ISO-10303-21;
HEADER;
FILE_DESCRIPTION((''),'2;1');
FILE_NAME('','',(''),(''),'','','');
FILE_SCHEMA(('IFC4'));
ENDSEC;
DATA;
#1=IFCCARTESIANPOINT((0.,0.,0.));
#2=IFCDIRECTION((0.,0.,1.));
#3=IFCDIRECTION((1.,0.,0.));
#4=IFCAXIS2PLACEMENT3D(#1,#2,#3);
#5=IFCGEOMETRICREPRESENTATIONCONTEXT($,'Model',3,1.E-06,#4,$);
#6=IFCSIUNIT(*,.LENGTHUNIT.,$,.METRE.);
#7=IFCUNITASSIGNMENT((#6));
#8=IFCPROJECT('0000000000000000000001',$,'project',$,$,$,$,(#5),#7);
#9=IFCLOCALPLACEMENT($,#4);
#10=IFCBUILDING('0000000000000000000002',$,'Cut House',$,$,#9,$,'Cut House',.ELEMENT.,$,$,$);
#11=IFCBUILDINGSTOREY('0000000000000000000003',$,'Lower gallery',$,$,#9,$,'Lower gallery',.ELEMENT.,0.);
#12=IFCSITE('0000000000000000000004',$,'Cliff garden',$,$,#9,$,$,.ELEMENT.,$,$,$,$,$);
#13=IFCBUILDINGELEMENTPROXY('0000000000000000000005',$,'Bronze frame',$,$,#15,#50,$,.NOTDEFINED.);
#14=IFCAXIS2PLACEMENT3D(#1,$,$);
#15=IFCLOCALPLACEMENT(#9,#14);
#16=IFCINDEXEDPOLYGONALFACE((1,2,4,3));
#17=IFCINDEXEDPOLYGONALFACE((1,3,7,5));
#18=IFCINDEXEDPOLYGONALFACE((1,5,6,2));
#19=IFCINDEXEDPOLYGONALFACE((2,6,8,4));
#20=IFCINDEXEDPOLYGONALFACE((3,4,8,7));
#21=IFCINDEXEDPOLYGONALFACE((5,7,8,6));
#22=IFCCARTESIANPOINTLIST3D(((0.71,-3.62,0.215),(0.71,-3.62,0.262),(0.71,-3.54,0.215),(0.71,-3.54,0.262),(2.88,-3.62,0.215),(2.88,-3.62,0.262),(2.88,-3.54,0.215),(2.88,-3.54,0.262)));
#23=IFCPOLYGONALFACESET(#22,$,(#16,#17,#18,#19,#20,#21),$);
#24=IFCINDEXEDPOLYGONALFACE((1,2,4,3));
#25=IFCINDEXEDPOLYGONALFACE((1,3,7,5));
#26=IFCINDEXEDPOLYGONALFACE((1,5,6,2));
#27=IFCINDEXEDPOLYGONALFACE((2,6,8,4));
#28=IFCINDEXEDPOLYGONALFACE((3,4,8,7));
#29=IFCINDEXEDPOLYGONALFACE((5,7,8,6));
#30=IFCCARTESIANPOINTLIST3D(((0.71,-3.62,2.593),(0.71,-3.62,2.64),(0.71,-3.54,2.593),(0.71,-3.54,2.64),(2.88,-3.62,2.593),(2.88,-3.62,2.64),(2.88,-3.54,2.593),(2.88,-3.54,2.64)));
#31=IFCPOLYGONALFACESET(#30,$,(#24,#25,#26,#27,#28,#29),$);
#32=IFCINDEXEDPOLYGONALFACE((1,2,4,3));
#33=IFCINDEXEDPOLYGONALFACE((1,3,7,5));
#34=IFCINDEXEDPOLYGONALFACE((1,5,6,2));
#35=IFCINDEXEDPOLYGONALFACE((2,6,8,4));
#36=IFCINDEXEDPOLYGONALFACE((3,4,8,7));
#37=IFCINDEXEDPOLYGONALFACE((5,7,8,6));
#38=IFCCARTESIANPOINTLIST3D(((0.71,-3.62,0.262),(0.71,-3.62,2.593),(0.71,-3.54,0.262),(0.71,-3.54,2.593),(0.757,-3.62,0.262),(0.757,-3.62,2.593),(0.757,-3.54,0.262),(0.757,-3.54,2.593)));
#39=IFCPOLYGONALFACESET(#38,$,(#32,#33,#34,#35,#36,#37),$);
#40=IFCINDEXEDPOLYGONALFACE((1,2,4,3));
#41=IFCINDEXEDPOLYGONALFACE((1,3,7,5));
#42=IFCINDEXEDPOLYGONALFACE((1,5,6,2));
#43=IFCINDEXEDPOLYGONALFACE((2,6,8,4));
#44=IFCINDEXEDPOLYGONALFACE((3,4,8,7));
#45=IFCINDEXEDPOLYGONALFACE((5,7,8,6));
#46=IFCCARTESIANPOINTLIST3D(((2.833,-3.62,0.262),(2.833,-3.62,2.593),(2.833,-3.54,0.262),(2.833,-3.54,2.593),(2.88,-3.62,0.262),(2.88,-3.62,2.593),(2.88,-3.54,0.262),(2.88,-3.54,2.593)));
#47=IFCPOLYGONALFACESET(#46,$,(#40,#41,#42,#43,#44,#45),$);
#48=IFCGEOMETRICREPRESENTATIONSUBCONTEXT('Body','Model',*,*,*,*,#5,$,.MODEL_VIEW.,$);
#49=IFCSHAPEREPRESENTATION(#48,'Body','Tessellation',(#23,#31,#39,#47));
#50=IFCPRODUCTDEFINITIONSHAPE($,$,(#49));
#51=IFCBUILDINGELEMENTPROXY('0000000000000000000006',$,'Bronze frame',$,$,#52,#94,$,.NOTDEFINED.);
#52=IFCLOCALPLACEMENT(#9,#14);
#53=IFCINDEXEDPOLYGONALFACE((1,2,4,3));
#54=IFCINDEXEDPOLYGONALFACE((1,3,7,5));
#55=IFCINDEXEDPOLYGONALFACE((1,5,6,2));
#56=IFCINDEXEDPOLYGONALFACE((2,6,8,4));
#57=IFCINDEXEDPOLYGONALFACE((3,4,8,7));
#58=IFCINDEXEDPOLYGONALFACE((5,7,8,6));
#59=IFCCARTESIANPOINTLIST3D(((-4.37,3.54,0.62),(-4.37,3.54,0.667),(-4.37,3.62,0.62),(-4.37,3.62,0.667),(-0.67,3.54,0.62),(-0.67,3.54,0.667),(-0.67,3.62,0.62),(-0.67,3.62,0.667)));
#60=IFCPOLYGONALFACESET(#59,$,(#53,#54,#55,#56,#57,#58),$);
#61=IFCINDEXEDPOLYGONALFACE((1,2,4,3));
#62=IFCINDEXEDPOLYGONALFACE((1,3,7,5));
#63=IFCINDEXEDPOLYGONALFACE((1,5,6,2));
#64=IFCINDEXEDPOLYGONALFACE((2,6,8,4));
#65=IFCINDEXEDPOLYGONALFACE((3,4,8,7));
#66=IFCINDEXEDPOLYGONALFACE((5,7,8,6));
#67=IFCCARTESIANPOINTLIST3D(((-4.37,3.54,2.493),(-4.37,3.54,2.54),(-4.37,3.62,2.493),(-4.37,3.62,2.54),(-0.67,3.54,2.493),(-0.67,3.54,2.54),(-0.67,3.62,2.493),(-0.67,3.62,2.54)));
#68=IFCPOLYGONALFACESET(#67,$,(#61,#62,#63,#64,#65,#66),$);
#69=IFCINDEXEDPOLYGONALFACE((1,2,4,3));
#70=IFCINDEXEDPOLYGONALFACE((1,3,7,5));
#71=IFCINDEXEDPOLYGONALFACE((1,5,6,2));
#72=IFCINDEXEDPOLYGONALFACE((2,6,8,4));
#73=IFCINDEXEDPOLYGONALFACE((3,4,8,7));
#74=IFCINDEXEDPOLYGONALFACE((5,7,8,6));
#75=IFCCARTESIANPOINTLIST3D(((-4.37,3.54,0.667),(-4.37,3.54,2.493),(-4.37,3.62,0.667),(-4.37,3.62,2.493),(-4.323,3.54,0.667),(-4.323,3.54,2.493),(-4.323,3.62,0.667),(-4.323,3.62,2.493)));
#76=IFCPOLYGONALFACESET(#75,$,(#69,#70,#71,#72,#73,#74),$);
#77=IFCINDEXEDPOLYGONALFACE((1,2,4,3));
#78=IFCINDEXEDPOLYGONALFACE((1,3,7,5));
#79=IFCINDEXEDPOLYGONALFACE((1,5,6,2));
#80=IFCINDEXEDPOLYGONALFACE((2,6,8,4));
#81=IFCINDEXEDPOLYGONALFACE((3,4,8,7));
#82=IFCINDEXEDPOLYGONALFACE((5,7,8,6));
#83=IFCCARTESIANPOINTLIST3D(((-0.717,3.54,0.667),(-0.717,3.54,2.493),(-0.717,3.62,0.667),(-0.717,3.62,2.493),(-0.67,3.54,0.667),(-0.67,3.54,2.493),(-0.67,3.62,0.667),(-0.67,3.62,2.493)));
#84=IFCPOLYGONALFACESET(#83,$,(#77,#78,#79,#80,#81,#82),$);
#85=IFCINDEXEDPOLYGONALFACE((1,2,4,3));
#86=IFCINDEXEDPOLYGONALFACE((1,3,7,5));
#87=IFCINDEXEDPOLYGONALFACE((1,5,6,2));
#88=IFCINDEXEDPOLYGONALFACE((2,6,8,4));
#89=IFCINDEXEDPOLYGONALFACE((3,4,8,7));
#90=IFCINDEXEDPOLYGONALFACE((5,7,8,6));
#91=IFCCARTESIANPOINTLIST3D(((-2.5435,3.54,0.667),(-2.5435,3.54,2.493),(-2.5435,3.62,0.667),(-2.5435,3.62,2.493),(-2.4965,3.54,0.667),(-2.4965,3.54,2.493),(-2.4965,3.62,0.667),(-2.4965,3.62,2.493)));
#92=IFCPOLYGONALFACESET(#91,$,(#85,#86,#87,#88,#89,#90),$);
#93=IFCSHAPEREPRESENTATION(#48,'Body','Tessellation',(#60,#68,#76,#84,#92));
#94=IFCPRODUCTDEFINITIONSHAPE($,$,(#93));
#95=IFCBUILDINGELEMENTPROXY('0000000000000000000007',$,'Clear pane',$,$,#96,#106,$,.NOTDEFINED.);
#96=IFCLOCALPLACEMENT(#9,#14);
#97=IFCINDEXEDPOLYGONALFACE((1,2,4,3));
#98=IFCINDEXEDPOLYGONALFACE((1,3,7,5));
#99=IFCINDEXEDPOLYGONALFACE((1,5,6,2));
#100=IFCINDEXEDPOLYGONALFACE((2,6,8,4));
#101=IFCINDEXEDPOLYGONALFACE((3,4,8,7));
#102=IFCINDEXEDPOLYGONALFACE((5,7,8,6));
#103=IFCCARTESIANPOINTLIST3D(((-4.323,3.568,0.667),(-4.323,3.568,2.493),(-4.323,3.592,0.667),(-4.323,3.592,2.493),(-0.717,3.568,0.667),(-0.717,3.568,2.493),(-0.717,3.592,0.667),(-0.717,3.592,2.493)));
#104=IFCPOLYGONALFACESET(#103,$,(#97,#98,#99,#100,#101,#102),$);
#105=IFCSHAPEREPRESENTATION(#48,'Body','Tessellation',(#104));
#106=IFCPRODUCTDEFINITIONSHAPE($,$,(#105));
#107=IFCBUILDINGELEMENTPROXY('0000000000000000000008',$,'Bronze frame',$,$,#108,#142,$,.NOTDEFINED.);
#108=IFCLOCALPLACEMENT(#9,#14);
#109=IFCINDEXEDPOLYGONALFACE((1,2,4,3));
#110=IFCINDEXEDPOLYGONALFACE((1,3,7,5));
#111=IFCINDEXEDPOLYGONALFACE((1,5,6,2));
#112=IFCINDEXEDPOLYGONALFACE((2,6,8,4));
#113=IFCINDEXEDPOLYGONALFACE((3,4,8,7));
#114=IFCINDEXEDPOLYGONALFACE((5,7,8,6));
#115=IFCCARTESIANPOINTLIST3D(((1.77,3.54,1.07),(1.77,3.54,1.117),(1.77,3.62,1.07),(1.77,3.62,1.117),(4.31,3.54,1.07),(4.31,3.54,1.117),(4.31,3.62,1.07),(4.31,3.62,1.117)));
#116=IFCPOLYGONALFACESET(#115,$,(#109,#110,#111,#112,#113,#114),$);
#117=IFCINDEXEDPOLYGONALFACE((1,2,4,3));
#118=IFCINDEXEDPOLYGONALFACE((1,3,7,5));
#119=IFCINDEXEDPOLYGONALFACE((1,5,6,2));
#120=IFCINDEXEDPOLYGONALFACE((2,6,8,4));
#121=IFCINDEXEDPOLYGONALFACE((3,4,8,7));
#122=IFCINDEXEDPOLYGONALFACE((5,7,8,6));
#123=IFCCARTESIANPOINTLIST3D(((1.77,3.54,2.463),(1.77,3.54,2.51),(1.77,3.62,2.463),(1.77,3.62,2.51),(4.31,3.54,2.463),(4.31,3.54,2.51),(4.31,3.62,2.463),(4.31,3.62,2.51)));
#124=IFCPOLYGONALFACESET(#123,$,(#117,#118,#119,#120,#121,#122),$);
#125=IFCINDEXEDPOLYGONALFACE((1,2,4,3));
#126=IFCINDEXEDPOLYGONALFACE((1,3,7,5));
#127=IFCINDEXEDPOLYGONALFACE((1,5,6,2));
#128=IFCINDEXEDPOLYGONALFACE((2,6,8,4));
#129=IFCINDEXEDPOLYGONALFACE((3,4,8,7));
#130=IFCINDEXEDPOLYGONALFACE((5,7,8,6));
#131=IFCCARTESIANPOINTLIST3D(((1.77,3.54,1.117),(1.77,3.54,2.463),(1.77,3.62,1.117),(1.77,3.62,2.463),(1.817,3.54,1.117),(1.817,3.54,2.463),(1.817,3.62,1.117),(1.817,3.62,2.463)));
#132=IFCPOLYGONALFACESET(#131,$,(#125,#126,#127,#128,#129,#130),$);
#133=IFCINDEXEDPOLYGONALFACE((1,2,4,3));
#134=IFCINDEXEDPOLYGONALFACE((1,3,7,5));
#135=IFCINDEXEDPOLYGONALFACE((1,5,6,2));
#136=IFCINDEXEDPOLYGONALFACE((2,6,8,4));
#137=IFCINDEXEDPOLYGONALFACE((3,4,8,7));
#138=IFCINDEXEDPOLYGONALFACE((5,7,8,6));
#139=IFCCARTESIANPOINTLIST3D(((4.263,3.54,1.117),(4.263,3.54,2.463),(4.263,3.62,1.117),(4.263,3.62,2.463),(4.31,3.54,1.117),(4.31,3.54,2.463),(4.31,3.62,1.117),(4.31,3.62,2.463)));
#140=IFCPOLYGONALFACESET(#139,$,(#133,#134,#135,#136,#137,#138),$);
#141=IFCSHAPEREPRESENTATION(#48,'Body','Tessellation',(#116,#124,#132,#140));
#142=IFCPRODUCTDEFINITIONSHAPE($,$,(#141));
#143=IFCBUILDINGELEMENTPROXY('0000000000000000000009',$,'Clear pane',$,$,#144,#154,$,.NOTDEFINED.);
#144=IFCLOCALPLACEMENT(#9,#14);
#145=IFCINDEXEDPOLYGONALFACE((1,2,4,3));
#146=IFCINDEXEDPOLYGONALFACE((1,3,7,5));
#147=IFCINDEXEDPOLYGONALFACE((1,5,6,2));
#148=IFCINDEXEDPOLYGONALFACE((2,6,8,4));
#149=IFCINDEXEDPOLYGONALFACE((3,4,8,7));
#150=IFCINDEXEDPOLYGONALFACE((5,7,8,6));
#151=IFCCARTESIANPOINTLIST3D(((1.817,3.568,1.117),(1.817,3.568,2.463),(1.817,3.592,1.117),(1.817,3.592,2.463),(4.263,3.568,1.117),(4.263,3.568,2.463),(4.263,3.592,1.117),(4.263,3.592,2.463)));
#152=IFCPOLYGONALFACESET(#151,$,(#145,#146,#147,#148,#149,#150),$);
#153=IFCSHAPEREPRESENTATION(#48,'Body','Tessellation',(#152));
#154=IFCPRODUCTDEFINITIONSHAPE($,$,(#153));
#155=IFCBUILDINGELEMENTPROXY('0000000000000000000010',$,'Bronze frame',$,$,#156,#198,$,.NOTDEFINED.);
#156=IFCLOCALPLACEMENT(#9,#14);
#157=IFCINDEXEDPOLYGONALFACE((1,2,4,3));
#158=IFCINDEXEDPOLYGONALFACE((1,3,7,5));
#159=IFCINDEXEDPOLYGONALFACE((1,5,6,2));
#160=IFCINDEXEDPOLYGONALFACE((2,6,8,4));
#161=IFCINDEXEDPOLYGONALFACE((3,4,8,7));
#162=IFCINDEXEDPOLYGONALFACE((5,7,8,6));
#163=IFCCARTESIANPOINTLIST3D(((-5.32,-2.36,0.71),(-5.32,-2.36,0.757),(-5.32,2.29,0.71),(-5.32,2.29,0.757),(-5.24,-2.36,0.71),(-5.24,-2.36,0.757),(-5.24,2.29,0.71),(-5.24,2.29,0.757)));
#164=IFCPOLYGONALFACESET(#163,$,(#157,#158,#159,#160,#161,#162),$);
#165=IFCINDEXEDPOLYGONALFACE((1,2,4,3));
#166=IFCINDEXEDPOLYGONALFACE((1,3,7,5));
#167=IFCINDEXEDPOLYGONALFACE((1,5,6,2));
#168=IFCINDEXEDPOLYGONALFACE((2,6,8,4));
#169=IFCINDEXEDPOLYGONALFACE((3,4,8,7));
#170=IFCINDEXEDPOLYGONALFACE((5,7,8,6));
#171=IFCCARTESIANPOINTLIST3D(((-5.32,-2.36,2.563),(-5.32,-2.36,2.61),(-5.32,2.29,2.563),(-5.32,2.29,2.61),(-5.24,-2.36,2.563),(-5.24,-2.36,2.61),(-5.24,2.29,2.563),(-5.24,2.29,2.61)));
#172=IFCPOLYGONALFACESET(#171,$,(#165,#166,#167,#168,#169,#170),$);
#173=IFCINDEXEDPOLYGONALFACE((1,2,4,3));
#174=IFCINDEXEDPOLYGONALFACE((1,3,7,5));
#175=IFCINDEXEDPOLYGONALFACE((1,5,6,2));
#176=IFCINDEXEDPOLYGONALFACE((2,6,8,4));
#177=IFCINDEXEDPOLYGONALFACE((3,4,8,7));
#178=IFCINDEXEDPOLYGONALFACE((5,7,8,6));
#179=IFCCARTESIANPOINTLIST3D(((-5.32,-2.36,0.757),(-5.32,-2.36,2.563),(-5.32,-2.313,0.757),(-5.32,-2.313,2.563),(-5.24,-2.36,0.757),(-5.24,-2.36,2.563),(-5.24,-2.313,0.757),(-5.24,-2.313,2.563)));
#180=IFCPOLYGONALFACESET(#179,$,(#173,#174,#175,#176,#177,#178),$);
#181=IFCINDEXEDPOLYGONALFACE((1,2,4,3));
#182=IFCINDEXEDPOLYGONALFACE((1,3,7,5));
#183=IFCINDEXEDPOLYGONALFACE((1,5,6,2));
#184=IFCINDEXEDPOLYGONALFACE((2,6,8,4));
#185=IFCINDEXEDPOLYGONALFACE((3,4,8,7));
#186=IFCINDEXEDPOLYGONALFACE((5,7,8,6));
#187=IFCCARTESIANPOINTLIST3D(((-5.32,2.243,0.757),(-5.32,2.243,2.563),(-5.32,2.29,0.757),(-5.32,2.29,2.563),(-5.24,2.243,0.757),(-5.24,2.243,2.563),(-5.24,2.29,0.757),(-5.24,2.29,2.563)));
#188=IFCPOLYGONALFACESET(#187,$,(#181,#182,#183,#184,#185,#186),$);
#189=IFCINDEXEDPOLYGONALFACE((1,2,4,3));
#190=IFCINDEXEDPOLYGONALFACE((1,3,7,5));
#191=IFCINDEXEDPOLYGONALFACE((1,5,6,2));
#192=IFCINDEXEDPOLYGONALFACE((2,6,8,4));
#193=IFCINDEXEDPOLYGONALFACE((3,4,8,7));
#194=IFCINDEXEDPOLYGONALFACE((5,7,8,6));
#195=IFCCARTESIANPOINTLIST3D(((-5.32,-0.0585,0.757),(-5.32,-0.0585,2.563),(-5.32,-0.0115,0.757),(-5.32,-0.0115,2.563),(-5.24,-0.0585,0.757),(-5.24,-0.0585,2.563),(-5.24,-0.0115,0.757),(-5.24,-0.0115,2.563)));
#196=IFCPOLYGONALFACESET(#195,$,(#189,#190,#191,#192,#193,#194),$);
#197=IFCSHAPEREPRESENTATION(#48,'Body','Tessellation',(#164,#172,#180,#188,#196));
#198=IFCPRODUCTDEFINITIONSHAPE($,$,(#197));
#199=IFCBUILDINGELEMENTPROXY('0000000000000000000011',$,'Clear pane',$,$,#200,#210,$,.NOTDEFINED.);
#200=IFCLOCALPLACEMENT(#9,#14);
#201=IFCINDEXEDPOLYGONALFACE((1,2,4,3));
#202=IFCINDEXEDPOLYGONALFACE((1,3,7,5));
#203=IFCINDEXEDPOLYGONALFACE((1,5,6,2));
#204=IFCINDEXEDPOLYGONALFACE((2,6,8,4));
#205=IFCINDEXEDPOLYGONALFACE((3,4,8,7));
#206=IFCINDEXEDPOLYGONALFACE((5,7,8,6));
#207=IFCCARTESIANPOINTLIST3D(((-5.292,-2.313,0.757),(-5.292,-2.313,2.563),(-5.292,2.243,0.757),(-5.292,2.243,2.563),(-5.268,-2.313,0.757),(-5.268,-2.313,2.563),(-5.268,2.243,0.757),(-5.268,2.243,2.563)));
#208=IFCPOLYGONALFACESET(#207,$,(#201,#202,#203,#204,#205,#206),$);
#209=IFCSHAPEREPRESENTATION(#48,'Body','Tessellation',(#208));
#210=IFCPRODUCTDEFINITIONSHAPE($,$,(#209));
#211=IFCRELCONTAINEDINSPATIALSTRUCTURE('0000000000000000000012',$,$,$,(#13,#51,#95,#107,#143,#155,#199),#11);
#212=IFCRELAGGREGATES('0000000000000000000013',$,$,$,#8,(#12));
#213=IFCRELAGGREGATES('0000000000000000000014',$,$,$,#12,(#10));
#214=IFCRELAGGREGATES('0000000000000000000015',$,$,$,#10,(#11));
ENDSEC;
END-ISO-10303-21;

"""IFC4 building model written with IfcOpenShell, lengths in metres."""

from ifc_helpers import new_model, si_unit, frame, origin_with_axes, place, context, subcontext, project, spatial, polyline, outline, extrude, element, save


model = new_model("IFC4")

# Units and contexts
model_context = context("Model", 3, precision=1e-06, world=origin_with_axes())
body_context = subcontext(model_context, "Body", "Model", "MODEL_VIEW")
ifc_project = project(units=[si_unit("LENGTHUNIT", "METRE")], contexts=[model_context])

# Site, building, storey
placement = place(None, origin_with_axes())
site = spatial("IfcSite", under=ifc_project, at=placement, Name="Cliff garden", CompositionType="ELEMENT")
building = spatial("IfcBuilding", under=site, at=placement, Name="Cut House", LongName="Cut House", CompositionType="ELEMENT")
storey = spatial("IfcBuildingStorey", under=building, at=placement, Name="Lower gallery", LongName="Lower gallery", CompositionType="ELEMENT", Elevation=0.0)

# Building element proxies
element("IfcBuildingElementProxy", 1, at=placement, inside=storey, Name="Bronze frame", PredefinedType="NOTDEFINED", context=body_context, shape_type="SweptSolid", body=[
    extrude(outline(polyline([(0.0, 0.0), (2.17, 0.0), (2.17, 0.08), (0.0, 0.08), (0.0, 0.0)])), frame((0.71, -3.62, 0.215), z_axis=(0.0, 0.0, 1.0), x_axis=(1.0, 0.0, 0.0)), (0.0, 0.0, 1.0), 0.047),
    extrude(outline(polyline([(0.0, 0.0), (2.17, 0.0), (2.17, 0.08), (0.0, 0.08), (0.0, 0.0)])), frame((0.71, -3.62, 2.593), z_axis=(0.0, 0.0, 1.0), x_axis=(1.0, 0.0, 0.0)), (0.0, 0.0, 1.0), 0.047),
    extrude(outline(polyline([(0.0, 0.0), (0.047, 0.0), (0.047, 0.08), (0.0, 0.08), (0.0, 0.0)])), frame((0.71, -3.62, 0.262), z_axis=(0.0, 0.0, 1.0), x_axis=(1.0, 0.0, 0.0)), (0.0, 0.0, 1.0), 2.331),
    extrude(outline(polyline([(0.0, 0.0), (0.047, 0.0), (0.047, 0.08), (0.0, 0.08), (0.0, 0.0)])), frame((2.833, -3.62, 0.262), z_axis=(0.0, 0.0, 1.0), x_axis=(1.0, 0.0, 0.0)), (0.0, 0.0, 1.0), 2.331),
])
element("IfcBuildingElementProxy", 2, at=placement, inside=storey, Name="Bronze frame", PredefinedType="NOTDEFINED", context=body_context, shape_type="SweptSolid", body=[
    extrude(outline(polyline([(0.0, 0.0), (3.7, 0.0), (3.7, 0.08), (0.0, 0.08), (0.0, 0.0)])), frame((-4.37, 3.54, 0.62), z_axis=(0.0, 0.0, 1.0), x_axis=(1.0, 0.0, 0.0)), (0.0, 0.0, 1.0), 0.047),
    extrude(outline(polyline([(0.0, 0.0), (3.7, 0.0), (3.7, 0.08), (0.0, 0.08), (0.0, 0.0)])), frame((-4.37, 3.54, 2.493), z_axis=(0.0, 0.0, 1.0), x_axis=(1.0, 0.0, 0.0)), (0.0, 0.0, 1.0), 0.047),
    extrude(outline(polyline([(0.0, 0.0), (0.047, 0.0), (0.047, 0.08), (0.0, 0.08), (0.0, 0.0)])), frame((-4.37, 3.54, 0.667), z_axis=(0.0, 0.0, 1.0), x_axis=(1.0, 0.0, 0.0)), (0.0, 0.0, 1.0), 1.826),
    extrude(outline(polyline([(0.0, 0.0), (0.047, 0.0), (0.047, 0.08), (0.0, 0.08), (0.0, 0.0)])), frame((-0.717, 3.54, 0.667), z_axis=(0.0, 0.0, 1.0), x_axis=(1.0, 0.0, 0.0)), (0.0, 0.0, 1.0), 1.826),
    extrude(outline(polyline([(0.0, 0.0), (0.047, 0.0), (0.047, 0.08), (0.0, 0.08), (0.0, 0.0)])), frame((-2.5435, 3.54, 0.667), z_axis=(0.0, 0.0, 1.0), x_axis=(1.0, 0.0, 0.0)), (0.0, 0.0, 1.0), 1.826),
])
element("IfcBuildingElementProxy", 3, at=placement, inside=storey, Name="Clear pane", PredefinedType="NOTDEFINED", context=body_context, shape_type="SweptSolid", body=[
    extrude(outline(polyline([(0.0, 0.0), (3.606, 0.0), (3.606, 0.024), (0.0, 0.024), (0.0, 0.0)])), frame((-4.323, 3.568, 0.667), z_axis=(0.0, 0.0, 1.0), x_axis=(1.0, 0.0, 0.0)), (0.0, 0.0, 1.0), 1.826),
])
element("IfcBuildingElementProxy", 4, at=placement, inside=storey, Name="Bronze frame", PredefinedType="NOTDEFINED", context=body_context, shape_type="SweptSolid", body=[
    extrude(outline(polyline([(0.0, 0.0), (2.54, 0.0), (2.54, 0.08), (0.0, 0.08), (0.0, 0.0)])), frame((1.77, 3.54, 1.07), z_axis=(0.0, 0.0, 1.0), x_axis=(1.0, 0.0, 0.0)), (0.0, 0.0, 1.0), 0.047),
    extrude(outline(polyline([(0.0, 0.0), (2.54, 0.0), (2.54, 0.08), (0.0, 0.08), (0.0, 0.0)])), frame((1.77, 3.54, 2.463), z_axis=(0.0, 0.0, 1.0), x_axis=(1.0, 0.0, 0.0)), (0.0, 0.0, 1.0), 0.047),
    extrude(outline(polyline([(0.0, 0.0), (0.047, 0.0), (0.047, 0.08), (0.0, 0.08), (0.0, 0.0)])), frame((1.77, 3.54, 1.117), z_axis=(0.0, 0.0, 1.0), x_axis=(1.0, 0.0, 0.0)), (0.0, 0.0, 1.0), 1.346),
    extrude(outline(polyline([(0.0, 0.0), (0.047, 0.0), (0.047, 0.08), (0.0, 0.08), (0.0, 0.0)])), frame((4.263, 3.54, 1.117), z_axis=(0.0, 0.0, 1.0), x_axis=(1.0, 0.0, 0.0)), (0.0, 0.0, 1.0), 1.346),
])
element("IfcBuildingElementProxy", 5, at=placement, inside=storey, Name="Clear pane", PredefinedType="NOTDEFINED", context=body_context, shape_type="SweptSolid", body=[
    extrude(outline(polyline([(0.0, 0.0), (2.446, 0.0), (2.446, 0.024), (0.0, 0.024), (0.0, 0.0)])), frame((1.817, 3.568, 1.117), z_axis=(0.0, 0.0, 1.0), x_axis=(1.0, 0.0, 0.0)), (0.0, 0.0, 1.0), 1.346),
])
element("IfcBuildingElementProxy", 6, at=placement, inside=storey, Name="Bronze frame", PredefinedType="NOTDEFINED", context=body_context, shape_type="SweptSolid", body=[
    extrude(outline(polyline([(0.0, 0.0), (0.08, 0.0), (0.08, 4.65), (0.0, 4.65), (0.0, 0.0)])), frame((-5.32, -2.36, 0.71), z_axis=(0.0, 0.0, 1.0), x_axis=(1.0, 0.0, 0.0)), (0.0, 0.0, 1.0), 0.047),
    extrude(outline(polyline([(0.0, 0.0), (0.08, 0.0), (0.08, 4.65), (0.0, 4.65), (0.0, 0.0)])), frame((-5.32, -2.36, 2.563), z_axis=(0.0, 0.0, 1.0), x_axis=(1.0, 0.0, 0.0)), (0.0, 0.0, 1.0), 0.047),
    extrude(outline(polyline([(0.0, 0.0), (0.08, 0.0), (0.08, 0.047), (0.0, 0.047), (0.0, 0.0)])), frame((-5.32, -2.36, 0.757), z_axis=(0.0, 0.0, 1.0), x_axis=(1.0, 0.0, 0.0)), (0.0, 0.0, 1.0), 1.806),
    extrude(outline(polyline([(0.0, 0.0), (0.08, 0.0), (0.08, 0.047), (0.0, 0.047), (0.0, 0.0)])), frame((-5.32, 2.243, 0.757), z_axis=(0.0, 0.0, 1.0), x_axis=(1.0, 0.0, 0.0)), (0.0, 0.0, 1.0), 1.806),
    extrude(outline(polyline([(0.0, 0.0), (0.08, 0.0), (0.08, 0.047), (0.0, 0.047), (0.0, 0.0)])), frame((-5.32, -0.0585, 0.757), z_axis=(0.0, 0.0, 1.0), x_axis=(1.0, 0.0, 0.0)), (0.0, 0.0, 1.0), 1.806),
])
element("IfcBuildingElementProxy", 7, at=placement, inside=storey, Name="Clear pane", PredefinedType="NOTDEFINED", context=body_context, shape_type="SweptSolid", body=[
    extrude(outline(polyline([(0.0, 0.0), (0.024, 0.0), (0.024, 4.556), (0.0, 4.556), (0.0, 0.0)])), frame((-5.292, -2.313, 0.757), z_axis=(0.0, 0.0, 1.0), x_axis=(1.0, 0.0, 0.0)), (0.0, 0.0, 1.0), 1.806),
])

save(model, "model.ifc")
